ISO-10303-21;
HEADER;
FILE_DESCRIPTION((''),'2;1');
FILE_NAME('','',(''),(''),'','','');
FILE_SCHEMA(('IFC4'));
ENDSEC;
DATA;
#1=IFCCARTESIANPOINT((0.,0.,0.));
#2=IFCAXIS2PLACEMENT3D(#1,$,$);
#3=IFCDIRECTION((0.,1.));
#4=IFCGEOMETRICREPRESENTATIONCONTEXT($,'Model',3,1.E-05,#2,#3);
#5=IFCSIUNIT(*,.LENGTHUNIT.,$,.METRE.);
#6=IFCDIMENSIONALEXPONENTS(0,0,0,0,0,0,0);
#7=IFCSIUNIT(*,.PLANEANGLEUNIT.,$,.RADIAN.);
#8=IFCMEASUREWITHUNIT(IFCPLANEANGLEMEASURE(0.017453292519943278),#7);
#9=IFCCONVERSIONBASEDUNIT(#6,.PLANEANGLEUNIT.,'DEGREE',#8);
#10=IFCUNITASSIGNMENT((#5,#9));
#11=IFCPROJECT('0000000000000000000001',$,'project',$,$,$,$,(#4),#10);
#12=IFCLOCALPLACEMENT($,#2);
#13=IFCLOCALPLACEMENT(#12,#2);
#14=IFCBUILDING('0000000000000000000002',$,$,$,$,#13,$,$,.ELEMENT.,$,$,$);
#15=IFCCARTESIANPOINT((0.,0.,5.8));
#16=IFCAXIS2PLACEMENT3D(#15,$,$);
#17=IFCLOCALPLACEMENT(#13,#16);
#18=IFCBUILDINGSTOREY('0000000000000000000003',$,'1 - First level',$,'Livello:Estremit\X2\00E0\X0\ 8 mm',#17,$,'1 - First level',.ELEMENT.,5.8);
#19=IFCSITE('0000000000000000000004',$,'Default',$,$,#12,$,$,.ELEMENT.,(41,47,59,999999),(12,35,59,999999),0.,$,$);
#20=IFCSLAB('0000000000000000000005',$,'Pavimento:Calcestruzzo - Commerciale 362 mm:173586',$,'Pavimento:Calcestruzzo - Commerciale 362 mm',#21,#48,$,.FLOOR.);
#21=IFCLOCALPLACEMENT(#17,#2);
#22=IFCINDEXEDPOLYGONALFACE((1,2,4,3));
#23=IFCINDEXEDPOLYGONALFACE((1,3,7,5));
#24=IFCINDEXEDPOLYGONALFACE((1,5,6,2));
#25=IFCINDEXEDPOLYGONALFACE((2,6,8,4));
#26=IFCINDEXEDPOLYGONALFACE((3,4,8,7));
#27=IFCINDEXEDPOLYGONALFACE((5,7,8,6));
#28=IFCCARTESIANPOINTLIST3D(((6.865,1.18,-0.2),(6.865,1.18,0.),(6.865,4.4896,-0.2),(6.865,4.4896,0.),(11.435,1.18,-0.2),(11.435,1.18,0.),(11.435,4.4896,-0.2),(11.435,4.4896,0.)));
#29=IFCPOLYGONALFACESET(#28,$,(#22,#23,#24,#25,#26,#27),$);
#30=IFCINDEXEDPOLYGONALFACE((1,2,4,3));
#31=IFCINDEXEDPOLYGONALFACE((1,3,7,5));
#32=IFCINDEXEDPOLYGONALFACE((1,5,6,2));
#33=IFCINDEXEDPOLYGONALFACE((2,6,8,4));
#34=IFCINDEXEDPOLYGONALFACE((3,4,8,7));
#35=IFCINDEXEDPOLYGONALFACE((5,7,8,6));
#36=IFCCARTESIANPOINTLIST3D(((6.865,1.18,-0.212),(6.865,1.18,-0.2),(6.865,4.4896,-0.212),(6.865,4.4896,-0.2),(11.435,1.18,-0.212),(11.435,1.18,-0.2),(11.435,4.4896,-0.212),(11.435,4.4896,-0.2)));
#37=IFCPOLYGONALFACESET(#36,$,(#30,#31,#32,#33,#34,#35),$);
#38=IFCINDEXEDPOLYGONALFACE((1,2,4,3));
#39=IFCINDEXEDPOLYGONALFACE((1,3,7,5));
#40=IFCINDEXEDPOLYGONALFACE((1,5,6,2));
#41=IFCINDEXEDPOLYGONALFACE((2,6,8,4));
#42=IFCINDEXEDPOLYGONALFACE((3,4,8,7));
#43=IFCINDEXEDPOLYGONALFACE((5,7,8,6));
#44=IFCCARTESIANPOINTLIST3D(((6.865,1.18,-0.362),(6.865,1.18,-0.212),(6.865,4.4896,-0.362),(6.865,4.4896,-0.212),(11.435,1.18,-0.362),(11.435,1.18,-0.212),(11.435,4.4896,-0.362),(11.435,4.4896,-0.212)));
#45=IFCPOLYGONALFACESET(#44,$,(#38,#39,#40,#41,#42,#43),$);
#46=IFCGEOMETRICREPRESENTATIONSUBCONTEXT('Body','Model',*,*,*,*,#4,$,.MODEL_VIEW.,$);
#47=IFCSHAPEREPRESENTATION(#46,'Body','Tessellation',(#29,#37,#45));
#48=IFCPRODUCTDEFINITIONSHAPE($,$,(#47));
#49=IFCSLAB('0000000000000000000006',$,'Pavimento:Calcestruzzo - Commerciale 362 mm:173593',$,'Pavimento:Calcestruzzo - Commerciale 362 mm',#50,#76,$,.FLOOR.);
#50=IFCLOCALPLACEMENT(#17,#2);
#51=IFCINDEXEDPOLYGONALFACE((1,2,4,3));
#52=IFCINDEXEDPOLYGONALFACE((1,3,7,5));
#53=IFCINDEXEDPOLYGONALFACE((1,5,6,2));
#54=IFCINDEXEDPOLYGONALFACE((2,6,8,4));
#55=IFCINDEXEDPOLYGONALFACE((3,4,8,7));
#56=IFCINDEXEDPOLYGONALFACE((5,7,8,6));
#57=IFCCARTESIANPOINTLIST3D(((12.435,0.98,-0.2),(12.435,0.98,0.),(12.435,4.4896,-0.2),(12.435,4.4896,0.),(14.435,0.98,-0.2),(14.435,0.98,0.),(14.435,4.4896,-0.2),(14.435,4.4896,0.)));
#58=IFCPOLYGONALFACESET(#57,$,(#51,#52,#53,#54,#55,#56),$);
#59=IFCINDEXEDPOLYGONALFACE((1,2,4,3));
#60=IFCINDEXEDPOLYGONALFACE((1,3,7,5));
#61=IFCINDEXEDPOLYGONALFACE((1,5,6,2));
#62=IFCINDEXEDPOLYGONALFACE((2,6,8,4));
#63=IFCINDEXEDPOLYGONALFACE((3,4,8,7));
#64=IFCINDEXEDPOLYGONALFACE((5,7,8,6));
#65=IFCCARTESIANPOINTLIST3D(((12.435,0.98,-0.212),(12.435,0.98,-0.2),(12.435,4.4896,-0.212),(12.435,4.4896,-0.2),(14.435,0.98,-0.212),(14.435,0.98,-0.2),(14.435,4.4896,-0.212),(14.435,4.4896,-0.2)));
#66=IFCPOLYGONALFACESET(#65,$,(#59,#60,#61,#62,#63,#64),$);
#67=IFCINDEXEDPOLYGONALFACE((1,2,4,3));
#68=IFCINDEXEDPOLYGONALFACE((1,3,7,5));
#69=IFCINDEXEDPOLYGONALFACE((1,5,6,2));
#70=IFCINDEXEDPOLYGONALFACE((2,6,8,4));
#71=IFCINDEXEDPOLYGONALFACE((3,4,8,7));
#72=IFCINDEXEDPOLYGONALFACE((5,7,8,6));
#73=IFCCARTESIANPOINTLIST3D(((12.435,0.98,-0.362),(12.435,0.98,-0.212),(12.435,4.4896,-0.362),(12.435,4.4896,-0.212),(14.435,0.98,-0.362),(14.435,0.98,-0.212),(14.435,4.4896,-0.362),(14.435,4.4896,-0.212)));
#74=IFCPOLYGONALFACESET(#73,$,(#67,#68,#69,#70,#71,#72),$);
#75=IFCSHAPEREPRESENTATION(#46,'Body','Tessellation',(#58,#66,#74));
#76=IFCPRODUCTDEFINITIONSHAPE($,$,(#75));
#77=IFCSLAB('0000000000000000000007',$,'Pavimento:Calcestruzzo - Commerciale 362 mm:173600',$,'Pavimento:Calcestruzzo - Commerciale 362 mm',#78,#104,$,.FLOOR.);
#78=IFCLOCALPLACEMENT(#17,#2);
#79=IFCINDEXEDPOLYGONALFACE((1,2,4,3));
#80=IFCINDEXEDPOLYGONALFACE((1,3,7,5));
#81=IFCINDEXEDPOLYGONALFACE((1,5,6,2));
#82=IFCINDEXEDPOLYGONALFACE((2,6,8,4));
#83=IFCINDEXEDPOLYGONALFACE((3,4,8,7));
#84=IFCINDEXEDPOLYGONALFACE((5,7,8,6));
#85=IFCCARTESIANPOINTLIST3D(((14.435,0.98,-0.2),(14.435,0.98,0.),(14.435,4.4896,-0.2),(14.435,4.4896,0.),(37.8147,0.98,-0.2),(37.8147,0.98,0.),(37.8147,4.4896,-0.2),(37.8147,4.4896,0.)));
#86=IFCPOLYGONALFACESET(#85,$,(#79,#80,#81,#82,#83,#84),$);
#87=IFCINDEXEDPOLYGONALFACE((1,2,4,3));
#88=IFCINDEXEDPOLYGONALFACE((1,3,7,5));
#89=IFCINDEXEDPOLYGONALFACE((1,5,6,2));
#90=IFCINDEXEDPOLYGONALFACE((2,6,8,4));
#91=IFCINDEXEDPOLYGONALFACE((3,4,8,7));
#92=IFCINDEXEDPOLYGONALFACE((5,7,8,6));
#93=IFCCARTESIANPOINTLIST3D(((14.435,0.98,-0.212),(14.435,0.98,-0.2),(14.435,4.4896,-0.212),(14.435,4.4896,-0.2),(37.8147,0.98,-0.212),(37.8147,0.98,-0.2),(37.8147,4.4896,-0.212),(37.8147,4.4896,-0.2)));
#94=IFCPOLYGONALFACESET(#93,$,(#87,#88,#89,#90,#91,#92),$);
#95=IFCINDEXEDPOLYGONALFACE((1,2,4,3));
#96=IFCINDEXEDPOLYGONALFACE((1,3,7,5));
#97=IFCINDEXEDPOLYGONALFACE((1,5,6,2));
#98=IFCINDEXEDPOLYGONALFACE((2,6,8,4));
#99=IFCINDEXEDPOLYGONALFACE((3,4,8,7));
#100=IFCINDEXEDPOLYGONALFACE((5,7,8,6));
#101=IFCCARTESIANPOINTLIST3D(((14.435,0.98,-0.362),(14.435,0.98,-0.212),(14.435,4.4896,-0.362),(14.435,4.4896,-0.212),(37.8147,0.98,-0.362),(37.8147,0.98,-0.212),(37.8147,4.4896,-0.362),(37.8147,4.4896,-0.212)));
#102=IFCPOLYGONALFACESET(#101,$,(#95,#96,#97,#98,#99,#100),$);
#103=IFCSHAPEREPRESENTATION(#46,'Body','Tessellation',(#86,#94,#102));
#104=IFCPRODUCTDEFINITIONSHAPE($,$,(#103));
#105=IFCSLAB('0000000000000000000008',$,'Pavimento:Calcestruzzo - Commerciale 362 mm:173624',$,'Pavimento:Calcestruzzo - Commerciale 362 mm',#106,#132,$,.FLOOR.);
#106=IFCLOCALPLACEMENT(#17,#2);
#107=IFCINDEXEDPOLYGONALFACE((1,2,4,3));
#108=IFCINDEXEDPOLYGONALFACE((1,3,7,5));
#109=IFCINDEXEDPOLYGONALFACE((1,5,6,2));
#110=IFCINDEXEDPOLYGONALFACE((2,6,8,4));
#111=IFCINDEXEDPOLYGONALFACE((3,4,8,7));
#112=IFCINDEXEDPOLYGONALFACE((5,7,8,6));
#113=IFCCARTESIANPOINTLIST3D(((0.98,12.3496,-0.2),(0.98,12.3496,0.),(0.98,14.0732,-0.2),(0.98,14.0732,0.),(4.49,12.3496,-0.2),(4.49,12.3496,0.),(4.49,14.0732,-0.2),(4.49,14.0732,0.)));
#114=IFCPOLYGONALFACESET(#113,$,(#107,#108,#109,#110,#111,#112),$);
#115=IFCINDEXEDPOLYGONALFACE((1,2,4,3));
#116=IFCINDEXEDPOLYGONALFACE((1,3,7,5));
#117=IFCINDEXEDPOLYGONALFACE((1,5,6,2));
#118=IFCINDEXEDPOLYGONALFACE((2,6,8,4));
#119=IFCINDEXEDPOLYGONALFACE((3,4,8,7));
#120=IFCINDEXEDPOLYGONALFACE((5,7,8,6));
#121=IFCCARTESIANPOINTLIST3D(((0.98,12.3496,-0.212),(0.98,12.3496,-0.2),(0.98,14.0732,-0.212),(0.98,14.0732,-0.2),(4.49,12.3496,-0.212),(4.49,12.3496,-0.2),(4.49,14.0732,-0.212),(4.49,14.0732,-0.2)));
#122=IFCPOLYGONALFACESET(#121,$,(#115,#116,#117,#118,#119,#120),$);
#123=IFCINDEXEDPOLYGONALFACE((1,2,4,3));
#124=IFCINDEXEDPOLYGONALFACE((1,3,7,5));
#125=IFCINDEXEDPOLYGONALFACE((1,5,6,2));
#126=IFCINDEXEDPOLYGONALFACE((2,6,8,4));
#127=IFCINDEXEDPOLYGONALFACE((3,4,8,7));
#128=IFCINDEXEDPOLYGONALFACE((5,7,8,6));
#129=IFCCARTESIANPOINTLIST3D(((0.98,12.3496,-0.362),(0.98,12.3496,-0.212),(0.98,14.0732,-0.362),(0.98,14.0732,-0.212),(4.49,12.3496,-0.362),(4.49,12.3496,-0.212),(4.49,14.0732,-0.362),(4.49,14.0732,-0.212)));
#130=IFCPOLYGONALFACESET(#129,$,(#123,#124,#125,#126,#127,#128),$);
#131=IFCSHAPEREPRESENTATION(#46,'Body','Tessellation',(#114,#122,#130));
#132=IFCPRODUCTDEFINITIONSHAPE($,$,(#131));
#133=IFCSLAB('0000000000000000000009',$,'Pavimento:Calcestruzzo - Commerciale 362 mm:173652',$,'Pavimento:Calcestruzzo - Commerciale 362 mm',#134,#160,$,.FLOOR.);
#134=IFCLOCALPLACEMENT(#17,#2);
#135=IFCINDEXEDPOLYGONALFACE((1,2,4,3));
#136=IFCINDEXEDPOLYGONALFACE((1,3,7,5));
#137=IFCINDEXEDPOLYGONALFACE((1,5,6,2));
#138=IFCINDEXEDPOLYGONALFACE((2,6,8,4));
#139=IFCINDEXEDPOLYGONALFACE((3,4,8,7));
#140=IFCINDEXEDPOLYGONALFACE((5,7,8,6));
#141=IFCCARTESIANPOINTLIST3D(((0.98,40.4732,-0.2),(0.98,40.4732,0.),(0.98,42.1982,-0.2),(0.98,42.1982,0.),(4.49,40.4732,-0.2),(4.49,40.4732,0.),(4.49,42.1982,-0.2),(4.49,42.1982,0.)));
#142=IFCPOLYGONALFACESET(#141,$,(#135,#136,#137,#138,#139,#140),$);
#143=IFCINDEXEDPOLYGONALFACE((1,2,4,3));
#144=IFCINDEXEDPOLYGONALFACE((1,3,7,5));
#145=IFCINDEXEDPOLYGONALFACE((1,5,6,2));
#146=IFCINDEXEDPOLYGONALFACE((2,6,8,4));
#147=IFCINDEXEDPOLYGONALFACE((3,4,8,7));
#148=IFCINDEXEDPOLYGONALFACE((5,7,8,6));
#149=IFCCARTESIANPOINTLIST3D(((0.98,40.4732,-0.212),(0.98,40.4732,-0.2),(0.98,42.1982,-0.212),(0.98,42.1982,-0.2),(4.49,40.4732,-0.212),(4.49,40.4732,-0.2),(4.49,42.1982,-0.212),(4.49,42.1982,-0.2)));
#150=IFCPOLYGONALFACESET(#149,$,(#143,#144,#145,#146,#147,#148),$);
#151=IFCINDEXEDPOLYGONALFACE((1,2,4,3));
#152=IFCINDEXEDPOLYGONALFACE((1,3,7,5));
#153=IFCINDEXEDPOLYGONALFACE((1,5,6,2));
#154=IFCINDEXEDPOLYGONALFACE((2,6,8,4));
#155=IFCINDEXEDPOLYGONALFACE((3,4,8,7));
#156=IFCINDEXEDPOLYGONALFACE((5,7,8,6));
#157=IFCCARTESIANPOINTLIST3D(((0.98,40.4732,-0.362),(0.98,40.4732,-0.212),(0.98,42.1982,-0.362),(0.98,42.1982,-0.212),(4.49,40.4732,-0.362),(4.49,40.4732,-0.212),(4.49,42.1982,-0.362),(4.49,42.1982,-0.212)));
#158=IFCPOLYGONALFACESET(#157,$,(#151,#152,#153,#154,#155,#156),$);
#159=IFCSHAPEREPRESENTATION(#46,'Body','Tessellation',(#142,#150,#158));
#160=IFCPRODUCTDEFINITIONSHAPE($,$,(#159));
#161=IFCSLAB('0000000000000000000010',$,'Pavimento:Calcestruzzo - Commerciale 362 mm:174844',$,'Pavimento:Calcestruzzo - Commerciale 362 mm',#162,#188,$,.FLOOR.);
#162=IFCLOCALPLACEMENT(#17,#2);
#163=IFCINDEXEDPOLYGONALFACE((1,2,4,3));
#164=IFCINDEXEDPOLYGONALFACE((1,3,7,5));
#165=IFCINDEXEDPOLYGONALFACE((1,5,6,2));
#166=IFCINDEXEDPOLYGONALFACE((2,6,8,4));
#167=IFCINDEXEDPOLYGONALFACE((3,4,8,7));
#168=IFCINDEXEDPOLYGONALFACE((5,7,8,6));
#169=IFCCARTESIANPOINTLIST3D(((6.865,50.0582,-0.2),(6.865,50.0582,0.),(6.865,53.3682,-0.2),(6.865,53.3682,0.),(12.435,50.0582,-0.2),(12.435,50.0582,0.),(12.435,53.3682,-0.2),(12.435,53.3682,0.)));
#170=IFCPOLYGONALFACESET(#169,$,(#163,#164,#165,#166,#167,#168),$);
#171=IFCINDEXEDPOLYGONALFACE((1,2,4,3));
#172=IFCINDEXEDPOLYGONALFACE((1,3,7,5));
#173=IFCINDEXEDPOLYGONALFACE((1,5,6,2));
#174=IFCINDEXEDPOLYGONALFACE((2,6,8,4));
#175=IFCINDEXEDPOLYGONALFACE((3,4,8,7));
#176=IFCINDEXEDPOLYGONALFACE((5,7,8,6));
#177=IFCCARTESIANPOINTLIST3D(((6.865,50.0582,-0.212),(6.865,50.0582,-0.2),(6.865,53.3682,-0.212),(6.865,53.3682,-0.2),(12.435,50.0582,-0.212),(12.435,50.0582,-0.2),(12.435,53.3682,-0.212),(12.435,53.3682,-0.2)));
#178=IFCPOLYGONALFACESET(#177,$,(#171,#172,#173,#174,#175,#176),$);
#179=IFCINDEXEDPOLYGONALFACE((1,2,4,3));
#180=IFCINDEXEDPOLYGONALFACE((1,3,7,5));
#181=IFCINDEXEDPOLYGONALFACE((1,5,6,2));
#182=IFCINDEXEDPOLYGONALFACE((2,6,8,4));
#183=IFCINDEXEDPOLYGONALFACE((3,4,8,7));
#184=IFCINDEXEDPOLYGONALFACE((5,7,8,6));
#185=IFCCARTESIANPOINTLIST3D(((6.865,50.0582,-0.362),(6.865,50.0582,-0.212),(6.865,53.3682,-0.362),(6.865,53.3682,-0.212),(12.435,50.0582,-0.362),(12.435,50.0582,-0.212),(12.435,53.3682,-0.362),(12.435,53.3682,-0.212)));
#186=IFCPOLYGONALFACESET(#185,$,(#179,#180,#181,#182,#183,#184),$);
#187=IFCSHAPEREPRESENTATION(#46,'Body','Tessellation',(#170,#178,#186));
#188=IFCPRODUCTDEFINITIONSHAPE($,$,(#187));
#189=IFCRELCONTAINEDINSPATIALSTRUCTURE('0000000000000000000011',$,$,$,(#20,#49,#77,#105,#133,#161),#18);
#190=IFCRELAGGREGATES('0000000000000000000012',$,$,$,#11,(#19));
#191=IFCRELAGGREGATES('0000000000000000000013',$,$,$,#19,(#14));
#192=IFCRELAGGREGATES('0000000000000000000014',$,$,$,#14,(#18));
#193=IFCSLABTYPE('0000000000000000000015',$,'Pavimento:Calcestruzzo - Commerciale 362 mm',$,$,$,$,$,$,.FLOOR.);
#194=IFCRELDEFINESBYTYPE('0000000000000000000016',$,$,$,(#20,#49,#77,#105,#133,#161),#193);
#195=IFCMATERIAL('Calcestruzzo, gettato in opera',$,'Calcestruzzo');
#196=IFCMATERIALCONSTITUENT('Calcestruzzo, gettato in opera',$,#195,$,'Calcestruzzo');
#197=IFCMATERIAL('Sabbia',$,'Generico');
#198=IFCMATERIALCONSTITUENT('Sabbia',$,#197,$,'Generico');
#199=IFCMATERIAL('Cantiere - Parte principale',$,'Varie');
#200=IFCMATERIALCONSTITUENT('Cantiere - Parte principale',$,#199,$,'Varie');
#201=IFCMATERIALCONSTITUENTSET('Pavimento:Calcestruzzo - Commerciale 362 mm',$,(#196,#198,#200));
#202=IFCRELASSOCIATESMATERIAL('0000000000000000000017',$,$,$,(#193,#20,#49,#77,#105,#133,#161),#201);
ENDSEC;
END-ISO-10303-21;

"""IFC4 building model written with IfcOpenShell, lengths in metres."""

from ifc_helpers import new_model, entity, si_unit, converted_unit, direction, frame, origin, place, context, subcontext, project, spatial, indexed_curve, outline, extrude, material, constituent, constituent_set, type_object, element, save


model = new_model("IFC4")

# Units and contexts
model_context = context("Model", 3, precision=1e-05, world=origin(), true_north=direction((0.0, 1.0)))
body_context = subcontext(model_context, "Body", "Model", "MODEL_VIEW")
ifc_project = project(units=[si_unit("LENGTHUNIT", "METRE"), converted_unit("PLANEANGLEUNIT", "DEGREE", entity("IfcPlaneAngleMeasure", 0.017453292519943278), si_unit("PLANEANGLEUNIT", "RADIAN"), dimensions=[0, 0, 0, 0, 0, 0, 0])], contexts=[model_context])

# Site, building, storey
site_placement = place(None, origin())
site = spatial("IfcSite", under=ifc_project, at=site_placement, Name="Default", CompositionType="ELEMENT", RefLatitude=(41, 47, 59, 999999), RefLongitude=(12, 35, 59, 999999), RefElevation=0.0)
building_placement = place(site_placement, origin())
building = spatial("IfcBuilding", under=site, at=building_placement, CompositionType="ELEMENT")
storey_placement = place(building_placement, frame((0.0, 0.0, 5.8)))
storey = spatial("IfcBuildingStorey", under=building, at=storey_placement, Name="1 - First level", ObjectType="Livello:Estremità 8 mm", LongName="1 - First level", CompositionType="ELEMENT", Elevation=5.8)

# Slabs
ifc_material_1 = material(Name="Calcestruzzo, gettato in opera", Category="Calcestruzzo")
ifc_constituent_1 = constituent(ifc_material_1, Name="Calcestruzzo, gettato in opera", Category="Calcestruzzo")
ifc_material_2 = material(Name="Sabbia", Category="Generico")
ifc_constituent_2 = constituent(ifc_material_2, Name="Sabbia", Category="Generico")
ifc_material_3 = material(Name="Cantiere - Parte principale", Category="Varie")
ifc_constituent_3 = constituent(ifc_material_3, Name="Cantiere - Parte principale", Category="Varie")
ifc_constituent_set = constituent_set(constituents=[ifc_constituent_1, ifc_constituent_2, ifc_constituent_3], Name="Pavimento:Calcestruzzo - Commerciale 362 mm")
slab_type = type_object("IfcSlabType", Name="Pavimento:Calcestruzzo - Commerciale 362 mm", PredefinedType="FLOOR", material=ifc_constituent_set)
slab_1_placement = place(storey_placement, origin())
element("IfcSlab", 1, at=slab_1_placement, inside=storey, type_object=slab_type, material=ifc_constituent_set, Name="Pavimento:Calcestruzzo - Commerciale 362 mm:173586", ObjectType="Pavimento:Calcestruzzo - Commerciale 362 mm", PredefinedType="FLOOR", context=body_context, shape_type="SweptSolid", body=[
    extrude(outline(indexed_curve([(-1.6548, -2.285), (1.6548, -2.285), (1.6548, 2.285), (-1.6548, 2.285), (-1.6548, -2.285)], self_intersect=False)), frame((9.15, 2.8348, -0.2), z_axis=(0.0, 0.0, 1.0), x_axis=(0.0, 1.0, 0.0)), (0.0, 0.0, 1.0), 0.2),
    extrude(outline(indexed_curve([(-1.6548, -2.285), (1.6548, -2.285), (1.6548, 2.285), (-1.6548, 2.285), (-1.6548, -2.285)], self_intersect=False)), frame((9.15, 2.8348, -0.212), z_axis=(0.0, 0.0, 1.0), x_axis=(0.0, 1.0, 0.0)), (0.0, 0.0, 1.0), 0.012),
    extrude(outline(indexed_curve([(-1.6548, -2.285), (1.6548, -2.285), (1.6548, 2.285), (-1.6548, 2.285), (-1.6548, -2.285)], self_intersect=False)), frame((9.15, 2.8348, -0.362), z_axis=(0.0, 0.0, 1.0), x_axis=(0.0, 1.0, 0.0)), (0.0, 0.0, 1.0), 0.15),
])
slab_2_placement = place(storey_placement, origin())
element("IfcSlab", 2, at=slab_2_placement, inside=storey, type_object=slab_type, material=ifc_constituent_set, Name="Pavimento:Calcestruzzo - Commerciale 362 mm:173593", ObjectType="Pavimento:Calcestruzzo - Commerciale 362 mm", PredefinedType="FLOOR", context=body_context, shape_type="SweptSolid", body=[
    extrude(outline(indexed_curve([(-1.7548, -1.0), (1.7548, -1.0), (1.7548, 1.0), (-1.7548, 1.0), (-1.7548, -1.0)], self_intersect=False)), frame((13.435, 2.7348, -0.2), z_axis=(0.0, 0.0, 1.0), x_axis=(0.0, 1.0, 0.0)), (0.0, 0.0, 1.0), 0.2),
    extrude(outline(indexed_curve([(-1.7548, -1.0), (1.7548, -1.0), (1.7548, 1.0), (-1.7548, 1.0), (-1.7548, -1.0)], self_intersect=False)), frame((13.435, 2.7348, -0.212), z_axis=(0.0, 0.0, 1.0), x_axis=(0.0, 1.0, 0.0)), (0.0, 0.0, 1.0), 0.012),
    extrude(outline(indexed_curve([(-1.7548, -1.0), (1.7548, -1.0), (1.7548, 1.0), (-1.7548, 1.0), (-1.7548, -1.0)], self_intersect=False)), frame((13.435, 2.7348, -0.362), z_axis=(0.0, 0.0, 1.0), x_axis=(0.0, 1.0, 0.0)), (0.0, 0.0, 1.0), 0.15),
])
slab_3_placement = place(storey_placement, origin())
element("IfcSlab", 3, at=slab_3_placement, inside=storey, type_object=slab_type, material=ifc_constituent_set, Name="Pavimento:Calcestruzzo - Commerciale 362 mm:173600", ObjectType="Pavimento:Calcestruzzo - Commerciale 362 mm", PredefinedType="FLOOR", context=body_context, shape_type="SweptSolid", body=[
    extrude(outline(indexed_curve([(-1.7548, -11.6898), (1.7548, -11.6898), (1.7548, 11.6898), (-1.7548, 11.6898), (-1.7548, -11.6898)], self_intersect=False)), frame((26.1249, 2.7348, -0.2), z_axis=(0.0, 0.0, 1.0), x_axis=(0.0, 1.0, 0.0)), (0.0, 0.0, 1.0), 0.2),
    extrude(outline(indexed_curve([(-1.7548, -11.6898), (1.7548, -11.6898), (1.7548, 11.6898), (-1.7548, 11.6898), (-1.7548, -11.6898)], self_intersect=False)), frame((26.1249, 2.7348, -0.212), z_axis=(0.0, 0.0, 1.0), x_axis=(0.0, 1.0, 0.0)), (0.0, 0.0, 1.0), 0.012),
    extrude(outline(indexed_curve([(-1.7548, -11.6898), (1.7548, -11.6898), (1.7548, 11.6898), (-1.7548, 11.6898), (-1.7548, -11.6898)], self_intersect=False)), frame((26.1249, 2.7348, -0.362), z_axis=(0.0, 0.0, 1.0), x_axis=(0.0, 1.0, 0.0)), (0.0, 0.0, 1.0), 0.15),
])
slab_4_placement = place(storey_placement, origin())
element("IfcSlab", 4, at=slab_4_placement, inside=storey, type_object=slab_type, material=ifc_constituent_set, Name="Pavimento:Calcestruzzo - Commerciale 362 mm:173624", ObjectType="Pavimento:Calcestruzzo - Commerciale 362 mm", PredefinedType="FLOOR", context=body_context, shape_type="SweptSolid", body=[
    extrude(outline(indexed_curve([(-0.8618, -1.755), (0.8618, -1.755), (0.8618, 1.755), (-0.8618, 1.755), (-0.8618, -1.755)], self_intersect=False)), frame((2.735, 13.2114, -0.2), z_axis=(0.0, 0.0, 1.0), x_axis=(0.0, -1.0, 0.0)), (0.0, 0.0, 1.0), 0.2),
    extrude(outline(indexed_curve([(-0.8618, -1.755), (0.8618, -1.755), (0.8618, 1.755), (-0.8618, 1.755), (-0.8618, -1.755)], self_intersect=False)), frame((2.735, 13.2114, -0.212), z_axis=(0.0, 0.0, 1.0), x_axis=(0.0, -1.0, 0.0)), (0.0, 0.0, 1.0), 0.012),
    extrude(outline(indexed_curve([(-0.8618, -1.755), (0.8618, -1.755), (0.8618, 1.755), (-0.8618, 1.755), (-0.8618, -1.755)], self_intersect=False)), frame((2.735, 13.2114, -0.362), z_axis=(0.0, 0.0, 1.0), x_axis=(0.0, -1.0, 0.0)), (0.0, 0.0, 1.0), 0.15),
])
slab_5_placement = place(storey_placement, origin())
element("IfcSlab", 5, at=slab_5_placement, inside=storey, type_object=slab_type, material=ifc_constituent_set, Name="Pavimento:Calcestruzzo - Commerciale 362 mm:173652", ObjectType="Pavimento:Calcestruzzo - Commerciale 362 mm", PredefinedType="FLOOR", context=body_context, shape_type="SweptSolid", body=[
    extrude(outline(indexed_curve([(-1.755, -0.8625), (1.755, -0.8625), (1.755, 0.8625), (-1.755, 0.8625), (-1.755, -0.8625)], self_intersect=False)), frame((2.735, 41.3357, -0.2)), (0.0, 0.0, 1.0), 0.2),
    extrude(outline(indexed_curve([(-1.755, -0.8625), (1.755, -0.8625), (1.755, 0.8625), (-1.755, 0.8625), (-1.755, -0.8625)], self_intersect=False)), frame((2.735, 41.3357, -0.212)), (0.0, 0.0, 1.0), 0.012),
    extrude(outline(indexed_curve([(-1.755, -0.8625), (1.755, -0.8625), (1.755, 0.8625), (-1.755, 0.8625), (-1.755, -0.8625)], self_intersect=False)), frame((2.735, 41.3357, -0.362)), (0.0, 0.0, 1.0), 0.15),
])
slab_6_placement = place(storey_placement, origin())
element("IfcSlab", 6, at=slab_6_placement, inside=storey, type_object=slab_type, material=ifc_constituent_set, Name="Pavimento:Calcestruzzo - Commerciale 362 mm:174844", ObjectType="Pavimento:Calcestruzzo - Commerciale 362 mm", PredefinedType="FLOOR", context=body_context, shape_type="SweptSolid", body=[
    extrude(outline(indexed_curve([(-2.785, -1.655), (2.785, -1.655), (2.785, 1.655), (-2.785, 1.655), (-2.785, -1.655)], self_intersect=False)), frame((9.65, 51.7132, -0.2), z_axis=(0.0, 0.0, 1.0), x_axis=(-1.0, 0.0, 0.0)), (0.0, 0.0, 1.0), 0.2),
    extrude(outline(indexed_curve([(-2.785, -1.655), (2.785, -1.655), (2.785, 1.655), (-2.785, 1.655), (-2.785, -1.655)], self_intersect=False)), frame((9.65, 51.7132, -0.212), z_axis=(0.0, 0.0, 1.0), x_axis=(-1.0, 0.0, 0.0)), (0.0, 0.0, 1.0), 0.012),
    extrude(outline(indexed_curve([(-2.785, -1.655), (2.785, -1.655), (2.785, 1.655), (-2.785, 1.655), (-2.785, -1.655)], self_intersect=False)), frame((9.65, 51.7132, -0.362), z_axis=(0.0, 0.0, 1.0), x_axis=(-1.0, 0.0, 0.0)), (0.0, 0.0, 1.0), 0.15),
])

save(model, "model.ifc")
